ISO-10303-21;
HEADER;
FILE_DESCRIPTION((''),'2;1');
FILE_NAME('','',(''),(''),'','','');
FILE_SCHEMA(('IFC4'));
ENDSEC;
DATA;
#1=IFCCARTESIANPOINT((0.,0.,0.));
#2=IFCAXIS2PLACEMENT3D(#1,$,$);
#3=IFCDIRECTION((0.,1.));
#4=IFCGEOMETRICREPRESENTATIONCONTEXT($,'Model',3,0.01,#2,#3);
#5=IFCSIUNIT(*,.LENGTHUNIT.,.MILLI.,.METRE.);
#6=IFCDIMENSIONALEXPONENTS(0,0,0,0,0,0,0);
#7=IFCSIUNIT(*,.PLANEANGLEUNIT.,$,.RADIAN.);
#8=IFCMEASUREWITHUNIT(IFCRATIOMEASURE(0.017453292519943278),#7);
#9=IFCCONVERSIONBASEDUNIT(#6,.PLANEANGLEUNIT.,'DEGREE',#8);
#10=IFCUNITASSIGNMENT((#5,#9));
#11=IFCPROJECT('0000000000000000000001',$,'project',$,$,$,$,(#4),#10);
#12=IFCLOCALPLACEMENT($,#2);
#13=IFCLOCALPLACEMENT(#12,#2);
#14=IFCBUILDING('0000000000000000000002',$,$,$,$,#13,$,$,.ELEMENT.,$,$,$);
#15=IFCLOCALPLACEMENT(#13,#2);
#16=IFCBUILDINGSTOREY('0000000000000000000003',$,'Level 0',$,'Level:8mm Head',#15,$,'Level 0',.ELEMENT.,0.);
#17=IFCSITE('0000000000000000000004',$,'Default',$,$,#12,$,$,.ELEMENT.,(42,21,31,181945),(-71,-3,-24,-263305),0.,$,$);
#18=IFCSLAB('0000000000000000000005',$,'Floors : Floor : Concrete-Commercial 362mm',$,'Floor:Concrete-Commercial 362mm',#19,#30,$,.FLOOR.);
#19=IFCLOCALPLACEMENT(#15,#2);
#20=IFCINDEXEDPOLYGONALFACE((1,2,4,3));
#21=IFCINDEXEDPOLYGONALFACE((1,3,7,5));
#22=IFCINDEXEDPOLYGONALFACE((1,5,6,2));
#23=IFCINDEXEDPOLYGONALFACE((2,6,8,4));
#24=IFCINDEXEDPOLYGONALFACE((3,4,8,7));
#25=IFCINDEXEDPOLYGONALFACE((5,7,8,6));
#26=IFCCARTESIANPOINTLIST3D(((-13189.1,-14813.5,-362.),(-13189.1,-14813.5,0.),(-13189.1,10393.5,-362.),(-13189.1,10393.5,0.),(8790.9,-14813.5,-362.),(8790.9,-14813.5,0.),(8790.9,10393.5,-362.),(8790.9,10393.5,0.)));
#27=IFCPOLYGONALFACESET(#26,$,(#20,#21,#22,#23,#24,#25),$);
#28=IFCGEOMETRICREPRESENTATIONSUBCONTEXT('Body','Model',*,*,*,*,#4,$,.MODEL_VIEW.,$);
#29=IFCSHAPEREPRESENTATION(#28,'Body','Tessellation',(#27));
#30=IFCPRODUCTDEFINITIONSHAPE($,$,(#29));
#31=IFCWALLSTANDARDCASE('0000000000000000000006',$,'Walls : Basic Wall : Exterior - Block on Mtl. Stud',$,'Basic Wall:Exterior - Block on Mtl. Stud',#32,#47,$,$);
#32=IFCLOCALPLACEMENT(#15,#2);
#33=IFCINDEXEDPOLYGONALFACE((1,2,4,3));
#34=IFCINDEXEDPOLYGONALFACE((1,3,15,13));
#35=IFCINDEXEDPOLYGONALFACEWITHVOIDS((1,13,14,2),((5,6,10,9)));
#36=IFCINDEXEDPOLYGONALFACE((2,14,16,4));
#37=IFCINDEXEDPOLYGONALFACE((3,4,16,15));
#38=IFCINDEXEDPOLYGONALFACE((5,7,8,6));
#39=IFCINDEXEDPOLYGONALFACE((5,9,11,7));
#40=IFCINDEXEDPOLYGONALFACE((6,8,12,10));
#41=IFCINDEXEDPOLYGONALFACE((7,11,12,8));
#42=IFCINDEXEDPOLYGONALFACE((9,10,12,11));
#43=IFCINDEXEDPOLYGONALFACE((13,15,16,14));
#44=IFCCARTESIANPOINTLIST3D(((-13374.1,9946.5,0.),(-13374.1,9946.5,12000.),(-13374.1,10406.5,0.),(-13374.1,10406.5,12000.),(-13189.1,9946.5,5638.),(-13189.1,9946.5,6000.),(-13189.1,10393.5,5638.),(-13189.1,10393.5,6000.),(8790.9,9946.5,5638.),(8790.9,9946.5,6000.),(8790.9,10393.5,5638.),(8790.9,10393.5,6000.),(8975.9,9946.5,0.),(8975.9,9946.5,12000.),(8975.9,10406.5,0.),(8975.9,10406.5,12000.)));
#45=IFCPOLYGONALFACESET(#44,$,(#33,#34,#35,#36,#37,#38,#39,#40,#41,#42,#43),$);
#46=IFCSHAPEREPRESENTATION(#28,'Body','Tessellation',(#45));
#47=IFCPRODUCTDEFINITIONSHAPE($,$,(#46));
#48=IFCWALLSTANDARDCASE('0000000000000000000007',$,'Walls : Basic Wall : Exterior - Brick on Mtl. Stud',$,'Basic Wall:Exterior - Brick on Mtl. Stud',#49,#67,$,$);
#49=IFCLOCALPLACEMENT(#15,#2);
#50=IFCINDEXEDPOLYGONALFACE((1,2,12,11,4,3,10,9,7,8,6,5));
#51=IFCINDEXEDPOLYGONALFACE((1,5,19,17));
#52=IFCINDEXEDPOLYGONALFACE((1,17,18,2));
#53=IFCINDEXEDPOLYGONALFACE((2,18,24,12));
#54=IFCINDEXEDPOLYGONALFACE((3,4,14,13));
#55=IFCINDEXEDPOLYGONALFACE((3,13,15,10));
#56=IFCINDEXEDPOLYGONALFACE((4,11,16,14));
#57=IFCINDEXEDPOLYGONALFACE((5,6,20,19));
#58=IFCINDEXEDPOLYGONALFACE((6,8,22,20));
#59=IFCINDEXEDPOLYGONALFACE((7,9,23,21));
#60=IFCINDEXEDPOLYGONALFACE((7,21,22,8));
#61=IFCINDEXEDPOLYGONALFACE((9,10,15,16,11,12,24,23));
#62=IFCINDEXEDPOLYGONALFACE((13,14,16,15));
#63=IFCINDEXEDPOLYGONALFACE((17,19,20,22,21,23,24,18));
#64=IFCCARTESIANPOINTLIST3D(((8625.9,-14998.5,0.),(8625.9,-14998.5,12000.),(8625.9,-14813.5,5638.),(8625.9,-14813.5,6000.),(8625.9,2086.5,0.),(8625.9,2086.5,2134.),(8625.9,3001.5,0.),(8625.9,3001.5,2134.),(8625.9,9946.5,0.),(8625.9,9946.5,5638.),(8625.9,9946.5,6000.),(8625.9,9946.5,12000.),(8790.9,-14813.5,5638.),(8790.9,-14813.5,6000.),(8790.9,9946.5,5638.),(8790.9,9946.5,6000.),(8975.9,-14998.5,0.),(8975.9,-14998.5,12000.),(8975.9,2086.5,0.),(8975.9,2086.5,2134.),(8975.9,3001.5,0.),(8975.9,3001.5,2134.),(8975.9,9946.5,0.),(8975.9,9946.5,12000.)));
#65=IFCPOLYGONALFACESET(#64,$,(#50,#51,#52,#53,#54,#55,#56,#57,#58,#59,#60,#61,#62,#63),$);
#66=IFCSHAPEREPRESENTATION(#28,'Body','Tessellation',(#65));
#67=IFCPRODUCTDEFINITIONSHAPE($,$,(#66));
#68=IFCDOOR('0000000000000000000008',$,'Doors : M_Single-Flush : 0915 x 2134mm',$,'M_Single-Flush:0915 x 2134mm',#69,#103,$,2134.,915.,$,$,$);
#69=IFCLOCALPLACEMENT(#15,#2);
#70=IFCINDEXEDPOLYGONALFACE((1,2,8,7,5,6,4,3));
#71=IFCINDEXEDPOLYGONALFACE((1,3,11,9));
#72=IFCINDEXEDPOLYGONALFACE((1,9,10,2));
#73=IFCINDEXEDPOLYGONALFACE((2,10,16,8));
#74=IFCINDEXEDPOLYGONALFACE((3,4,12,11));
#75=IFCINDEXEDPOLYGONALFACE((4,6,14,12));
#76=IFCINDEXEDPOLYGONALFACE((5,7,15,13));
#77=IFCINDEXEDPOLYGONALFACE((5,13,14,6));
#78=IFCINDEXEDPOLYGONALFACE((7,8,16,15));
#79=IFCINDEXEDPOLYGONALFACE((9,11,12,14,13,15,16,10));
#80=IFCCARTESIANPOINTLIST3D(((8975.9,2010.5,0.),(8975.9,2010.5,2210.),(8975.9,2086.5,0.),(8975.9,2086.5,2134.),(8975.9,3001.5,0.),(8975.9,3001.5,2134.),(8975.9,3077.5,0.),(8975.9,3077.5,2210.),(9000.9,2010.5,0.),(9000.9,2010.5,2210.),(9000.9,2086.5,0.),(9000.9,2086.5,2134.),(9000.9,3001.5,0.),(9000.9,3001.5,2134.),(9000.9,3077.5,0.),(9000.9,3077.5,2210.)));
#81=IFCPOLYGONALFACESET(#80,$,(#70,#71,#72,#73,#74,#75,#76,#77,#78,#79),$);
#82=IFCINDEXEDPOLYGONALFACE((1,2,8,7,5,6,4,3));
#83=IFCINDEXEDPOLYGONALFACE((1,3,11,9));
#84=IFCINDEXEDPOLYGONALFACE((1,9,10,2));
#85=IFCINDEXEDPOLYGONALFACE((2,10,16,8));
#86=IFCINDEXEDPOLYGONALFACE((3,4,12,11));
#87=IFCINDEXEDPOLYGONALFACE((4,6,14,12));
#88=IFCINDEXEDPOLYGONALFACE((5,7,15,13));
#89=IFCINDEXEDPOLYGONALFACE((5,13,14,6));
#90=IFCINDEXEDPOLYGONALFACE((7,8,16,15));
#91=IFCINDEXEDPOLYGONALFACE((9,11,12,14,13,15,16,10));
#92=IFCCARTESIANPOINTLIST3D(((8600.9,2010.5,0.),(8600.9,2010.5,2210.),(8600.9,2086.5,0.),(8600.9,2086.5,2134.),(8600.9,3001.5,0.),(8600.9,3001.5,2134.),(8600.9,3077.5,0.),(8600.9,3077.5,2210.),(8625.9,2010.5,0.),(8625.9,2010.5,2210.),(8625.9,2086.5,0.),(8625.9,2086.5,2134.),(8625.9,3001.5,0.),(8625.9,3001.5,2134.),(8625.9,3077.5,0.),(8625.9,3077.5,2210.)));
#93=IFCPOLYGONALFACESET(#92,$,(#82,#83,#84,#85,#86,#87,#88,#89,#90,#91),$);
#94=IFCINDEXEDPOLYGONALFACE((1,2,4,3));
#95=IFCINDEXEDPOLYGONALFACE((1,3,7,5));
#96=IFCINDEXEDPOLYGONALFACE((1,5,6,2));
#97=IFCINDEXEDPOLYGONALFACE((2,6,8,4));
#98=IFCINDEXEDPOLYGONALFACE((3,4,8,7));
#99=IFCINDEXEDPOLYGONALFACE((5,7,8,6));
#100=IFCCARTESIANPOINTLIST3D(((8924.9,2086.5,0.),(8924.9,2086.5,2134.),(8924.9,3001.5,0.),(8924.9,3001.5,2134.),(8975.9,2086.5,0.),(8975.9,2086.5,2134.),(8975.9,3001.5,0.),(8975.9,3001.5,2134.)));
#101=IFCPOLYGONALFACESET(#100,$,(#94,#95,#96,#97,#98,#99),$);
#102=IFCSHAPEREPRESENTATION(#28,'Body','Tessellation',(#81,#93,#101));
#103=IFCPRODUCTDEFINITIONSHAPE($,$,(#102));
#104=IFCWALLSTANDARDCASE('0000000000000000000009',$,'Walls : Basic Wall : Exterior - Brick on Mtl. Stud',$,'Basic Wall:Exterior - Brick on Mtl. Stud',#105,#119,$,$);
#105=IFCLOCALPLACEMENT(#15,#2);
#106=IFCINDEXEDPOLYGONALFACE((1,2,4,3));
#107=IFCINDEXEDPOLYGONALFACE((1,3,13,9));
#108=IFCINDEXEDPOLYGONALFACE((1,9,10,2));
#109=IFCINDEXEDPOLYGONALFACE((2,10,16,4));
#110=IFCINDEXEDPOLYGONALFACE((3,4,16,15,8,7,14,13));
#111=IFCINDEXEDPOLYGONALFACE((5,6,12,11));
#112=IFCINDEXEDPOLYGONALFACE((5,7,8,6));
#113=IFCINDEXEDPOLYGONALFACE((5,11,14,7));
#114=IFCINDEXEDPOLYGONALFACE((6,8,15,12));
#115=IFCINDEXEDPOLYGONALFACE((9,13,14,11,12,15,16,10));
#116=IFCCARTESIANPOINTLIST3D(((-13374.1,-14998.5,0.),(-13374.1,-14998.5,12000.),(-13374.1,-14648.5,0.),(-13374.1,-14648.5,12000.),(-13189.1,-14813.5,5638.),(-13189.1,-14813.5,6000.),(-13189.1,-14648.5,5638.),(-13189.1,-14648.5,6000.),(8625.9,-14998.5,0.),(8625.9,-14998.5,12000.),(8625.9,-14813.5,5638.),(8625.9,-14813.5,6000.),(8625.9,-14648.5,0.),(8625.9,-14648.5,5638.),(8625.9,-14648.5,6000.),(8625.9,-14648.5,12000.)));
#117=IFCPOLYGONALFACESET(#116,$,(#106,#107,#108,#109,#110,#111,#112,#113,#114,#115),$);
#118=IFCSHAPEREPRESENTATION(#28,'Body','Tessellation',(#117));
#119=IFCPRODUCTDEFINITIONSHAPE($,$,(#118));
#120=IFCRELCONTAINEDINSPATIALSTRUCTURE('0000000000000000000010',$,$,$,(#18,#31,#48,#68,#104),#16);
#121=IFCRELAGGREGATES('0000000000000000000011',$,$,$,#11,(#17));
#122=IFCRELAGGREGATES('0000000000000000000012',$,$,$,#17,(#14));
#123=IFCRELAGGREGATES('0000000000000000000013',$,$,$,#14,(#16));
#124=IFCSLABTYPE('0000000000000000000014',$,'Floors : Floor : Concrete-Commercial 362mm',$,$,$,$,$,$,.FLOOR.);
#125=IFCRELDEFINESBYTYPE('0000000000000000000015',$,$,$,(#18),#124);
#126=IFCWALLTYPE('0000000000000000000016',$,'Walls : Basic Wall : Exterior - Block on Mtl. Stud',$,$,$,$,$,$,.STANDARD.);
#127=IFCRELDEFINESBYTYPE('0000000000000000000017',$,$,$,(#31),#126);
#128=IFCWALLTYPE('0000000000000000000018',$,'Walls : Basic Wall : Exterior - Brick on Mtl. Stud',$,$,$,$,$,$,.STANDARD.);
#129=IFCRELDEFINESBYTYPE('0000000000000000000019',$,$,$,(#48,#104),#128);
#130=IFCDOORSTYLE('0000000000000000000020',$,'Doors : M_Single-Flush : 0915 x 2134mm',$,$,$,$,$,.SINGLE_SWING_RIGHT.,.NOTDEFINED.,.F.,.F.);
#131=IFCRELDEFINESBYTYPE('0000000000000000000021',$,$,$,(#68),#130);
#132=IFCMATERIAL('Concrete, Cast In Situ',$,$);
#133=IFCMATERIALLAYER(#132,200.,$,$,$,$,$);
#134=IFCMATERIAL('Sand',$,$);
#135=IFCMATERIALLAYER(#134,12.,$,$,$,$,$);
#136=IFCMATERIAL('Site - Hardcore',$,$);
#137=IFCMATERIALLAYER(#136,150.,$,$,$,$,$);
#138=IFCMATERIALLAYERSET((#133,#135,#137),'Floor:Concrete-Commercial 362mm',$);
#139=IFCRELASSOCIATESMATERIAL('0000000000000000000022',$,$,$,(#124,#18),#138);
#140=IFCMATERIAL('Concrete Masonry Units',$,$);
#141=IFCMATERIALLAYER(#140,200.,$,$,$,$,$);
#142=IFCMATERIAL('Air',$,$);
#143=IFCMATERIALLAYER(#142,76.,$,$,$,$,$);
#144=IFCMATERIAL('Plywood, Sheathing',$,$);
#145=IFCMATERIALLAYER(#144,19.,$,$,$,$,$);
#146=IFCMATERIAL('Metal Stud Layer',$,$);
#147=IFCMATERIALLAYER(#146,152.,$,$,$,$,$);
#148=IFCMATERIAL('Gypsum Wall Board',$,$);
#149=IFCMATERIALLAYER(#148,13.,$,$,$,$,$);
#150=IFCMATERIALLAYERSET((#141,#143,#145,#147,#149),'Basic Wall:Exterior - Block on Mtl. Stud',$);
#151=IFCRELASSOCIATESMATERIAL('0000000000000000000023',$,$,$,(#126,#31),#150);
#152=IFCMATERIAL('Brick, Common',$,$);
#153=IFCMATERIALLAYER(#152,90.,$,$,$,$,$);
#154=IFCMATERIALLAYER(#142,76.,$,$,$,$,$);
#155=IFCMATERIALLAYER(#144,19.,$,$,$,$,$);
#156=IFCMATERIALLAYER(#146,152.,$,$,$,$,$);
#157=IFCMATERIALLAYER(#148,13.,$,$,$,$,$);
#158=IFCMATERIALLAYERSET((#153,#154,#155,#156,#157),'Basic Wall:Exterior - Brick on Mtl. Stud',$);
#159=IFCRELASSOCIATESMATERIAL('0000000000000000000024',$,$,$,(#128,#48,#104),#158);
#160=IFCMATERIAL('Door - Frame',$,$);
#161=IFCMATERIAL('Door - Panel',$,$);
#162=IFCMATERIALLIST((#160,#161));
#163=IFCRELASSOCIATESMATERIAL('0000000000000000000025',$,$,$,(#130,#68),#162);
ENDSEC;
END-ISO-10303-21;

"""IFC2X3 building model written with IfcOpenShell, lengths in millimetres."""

from ifc_helpers import new_model, entity, si_unit, converted_unit, direction, frame, frame_2d, origin, place, context, subcontext, project, spatial, polyline, rectangle, outline, extrude, source, transform, mapped, material, material_list, layer, layer_set, layer_usage, type_object, type_shapes, element, fill, save


model = new_model("IFC2X3")

# Units and contexts
model_context = context("Model", 3, precision=0.01, world=origin(), true_north=direction((0.0, 1.0)))
body_context = subcontext(model_context, "Body", "Model", "MODEL_VIEW")
ifc_project = project(units=[si_unit("LENGTHUNIT", "METRE", prefix="MILLI"), converted_unit("PLANEANGLEUNIT", "DEGREE", entity("IfcRatioMeasure", 0.017453292519943278), si_unit("PLANEANGLEUNIT", "RADIAN"), dimensions=[0, 0, 0, 0, 0, 0, 0])], contexts=[model_context])

# Site, building, storey
site_placement = place(None, origin())
site = spatial("IfcSite", under=ifc_project, at=site_placement, Name="Default", CompositionType="ELEMENT", RefLatitude=(42, 21, 31, 181945), RefLongitude=(-71, -3, -24, -263305), RefElevation=0.0)
building_placement = place(site_placement, origin())
building = spatial("IfcBuilding", under=site, at=building_placement, CompositionType="ELEMENT")
storey_placement = place(building_placement, origin())
storey = spatial("IfcBuildingStorey", under=building, at=storey_placement, Name="Level 0", ObjectType="Level:8mm Head", LongName="Level 0", CompositionType="ELEMENT", Elevation=0.0)

# Slab
ifc_material_1 = material(Name="Concrete, Cast In Situ")
ifc_layer_1 = layer(ifc_material_1, 200.0)
ifc_material_2 = material(Name="Sand")
ifc_layer_2 = layer(ifc_material_2, 12.0)
ifc_material_3 = material(Name="Site - Hardcore")
ifc_layer_3 = layer(ifc_material_3, 150.0)
ifc_layer_set_1 = layer_set([ifc_layer_1, ifc_layer_2, ifc_layer_3], Name="Floor:Concrete-Commercial 362mm")
ifc_layer_usage_1 = layer_usage(ifc_layer_set_1, "AXIS3", "POSITIVE", 0.0)
slab_type = type_object("IfcSlabType", Name="Floors : Floor : Concrete-Commercial 362mm", PredefinedType="FLOOR", material=ifc_layer_set_1)
slab_placement = place(storey_placement, origin())
element("IfcSlab", 1, at=slab_placement, inside=storey, type_object=slab_type, material=ifc_layer_usage_1, Name="Floors : Floor : Concrete-Commercial 362mm", ObjectType="Floor:Concrete-Commercial 362mm", PredefinedType="FLOOR", context=body_context, shape_type="SweptSolid", body=[
    extrude(rectangle(XDim=25207.0, YDim=21980.0, at=frame_2d((0.0, 0.0), x_axis=(1.0, 0.0))), frame((-2199.1, -2210.0, 0.0), z_axis=(0.0, 0.0, -1.0), x_axis=(0.0, 1.0, 0.0)), (0.0, 0.0, 1.0), 362.0),
])

# Wall, opening
ifc_material_4 = material(Name="Concrete Masonry Units")
ifc_layer_4 = layer(ifc_material_4, 200.0)
ifc_material_5 = material(Name="Air")
ifc_layer_5 = layer(ifc_material_5, 76.0)
ifc_material_6 = material(Name="Plywood, Sheathing")
ifc_layer_6 = layer(ifc_material_6, 19.0)
ifc_material_7 = material(Name="Metal Stud Layer")
ifc_layer_7 = layer(ifc_material_7, 152.0)
ifc_material_8 = material(Name="Gypsum Wall Board")
ifc_layer_8 = layer(ifc_material_8, 13.0)
ifc_layer_set_2 = layer_set([ifc_layer_4, ifc_layer_5, ifc_layer_6, ifc_layer_7, ifc_layer_8], Name="Basic Wall:Exterior - Block on Mtl. Stud")
ifc_layer_usage_2 = layer_usage(ifc_layer_set_2, "AXIS2", "POSITIVE", -230.0)
wall_type_1 = type_object("IfcWallType", Name="Walls : Basic Wall : Exterior - Block on Mtl. Stud", PredefinedType="STANDARD", material=ifc_layer_set_2)
wall_1_placement = place(storey_placement, frame((-13374.1, 10176.5, 0.0)))
wall_1 = element("IfcWallStandardCase", 2, at=wall_1_placement, inside=storey, type_object=wall_type_1, material=ifc_layer_usage_2, Name="Walls : Basic Wall : Exterior - Block on Mtl. Stud", ObjectType="Basic Wall:Exterior - Block on Mtl. Stud", context=body_context, shape_type="SweptSolid", body=[
    extrude(rectangle(XDim=22350.0, YDim=460.0, at=frame_2d((11175.0, 0.0), x_axis=(-1.0, 0.0))), origin(), (0.0, 0.0, 1.0), 12000.0),
])
opening_1_placement = place(storey_placement, frame((-13374.1, 10176.5, 0.0)))
element("IfcOpeningElement", 3, at=opening_1_placement, cuts=wall_1, ObjectType="Opening", context=body_context, shape_type="SweptSolid", body=[
    extrude(rectangle(XDim=21980.0, YDim=447.0, at=frame_2d((0.0, -74.5), x_axis=(1.0, 0.0))), frame((11175.0, -81.0, 5638.0), z_axis=(0.0, 0.0, 1.0), x_axis=(-1.0, 0.0, 0.0)), (0.0, 0.0, 1.0), 362.0),
])

# Wall, openings, door
ifc_material_9 = material(Name="Brick, Common")
ifc_layer_9 = layer(ifc_material_9, 90.0)
ifc_layer_10 = layer(ifc_material_5, 76.0)
ifc_layer_11 = layer(ifc_material_6, 19.0)
ifc_layer_12 = layer(ifc_material_7, 152.0)
ifc_layer_13 = layer(ifc_material_8, 13.0)
ifc_layer_set_3 = layer_set([ifc_layer_9, ifc_layer_10, ifc_layer_11, ifc_layer_12, ifc_layer_13], Name="Basic Wall:Exterior - Brick on Mtl. Stud")
ifc_layer_usage_3 = layer_usage(ifc_layer_set_3, "AXIS2", "NEGATIVE", 175.0)
wall_type_2 = type_object("IfcWallType", Name="Walls : Basic Wall : Exterior - Brick on Mtl. Stud", PredefinedType="STANDARD", material=ifc_layer_set_3)
wall_2_placement = place(storey_placement, frame((8800.9, 9946.5, 0.0), z_axis=(0.0, 0.0, 1.0), x_axis=(0.0, -1.0, 0.0)))
wall_2 = element("IfcWallStandardCase", 4, at=wall_2_placement, inside=storey, type_object=wall_type_2, material=ifc_layer_usage_3, Name="Walls : Basic Wall : Exterior - Brick on Mtl. Stud", ObjectType="Basic Wall:Exterior - Brick on Mtl. Stud", context=body_context, shape_type="SweptSolid", body=[
    extrude(rectangle(XDim=24945.0, YDim=350.0, at=frame_2d((12472.5, 0.0), x_axis=(-1.0, 0.0))), origin(), (0.0, 0.0, 1.0), 12000.0),
])
opening_2_placement = place(storey_placement, frame((8800.9, 9946.5, 0.0), z_axis=(0.0, 0.0, 1.0), x_axis=(0.0, -1.0, 0.0)))
element("IfcOpeningElement", 5, at=opening_2_placement, cuts=wall_2, ObjectType="Opening", context=body_context, shape_type="SweptSolid", body=[
    extrude(rectangle(XDim=165.0, YDim=24760.0, at=frame_2d((16.5, 2443.0), x_axis=(1.0, 0.0))), frame((14823.0, -109.0, 5638.0), z_axis=(0.0, 0.0, 1.0), x_axis=(0.0, 1.0, 0.0)), (0.0, 0.0, 1.0), 362.0),
])
opening_3_placement = place(wall_2_placement, frame((6945.0, -175.0, 0.0)))
opening_3 = element("IfcOpeningElement", 6, at=opening_3_placement, cuts=wall_2, ObjectType="Opening", context=body_context, shape_type="SweptSolid", body=[
    extrude(rectangle(XDim=915.0, YDim=2134.0, at=frame_2d((1067.0, 457.5), x_axis=(0.0, 1.0))), frame((0.0, 0.0, 0.0), z_axis=(0.0, 1.0, 0.0), x_axis=(0.0, 0.0, 1.0)), (0.0, 0.0, 1.0), 350.0),
])
ifc_material_10 = material(Name="Door - Frame")
ifc_material_11 = material(Name="Door - Panel")
ifc_material_list = material_list([ifc_material_10, ifc_material_11])
door_style_1 = type_object("IfcDoorStyle", Name="Doors : M_Single-Flush : 0915 x 2134mm", ConstructionType="NOTDEFINED", OperationType="SINGLE_SWING_RIGHT", ParameterTakesPrecedence=False, Sizeable=False, material=ifc_material_list)
shared_shape_1 = source(origin(), body_context, "Body", "SweptSolid", [
    extrude(outline(polyline([(-533.5, -1124.0), (533.5, -1124.0), (533.5, 1086.0), (457.5, 1086.0), (457.5, -1048.0), (-457.5, -1048.0), (-457.5, 1086.0), (-533.5, 1086.0), (-533.5, -1124.0)])), frame((457.5, 350.0, 1086.0), z_axis=(0.0, 1.0, 0.0), x_axis=(1.0, 0.0, 0.0)), (0.0, 0.0, 1.0), 25.0),
    extrude(outline(polyline([(-1124.0, -533.5), (1086.0, -533.5), (1086.0, -457.5), (-1048.0, -457.5), (-1048.0, 457.5), (1086.0, 457.5), (1086.0, 533.5), (-1124.0, 533.5), (-1124.0, -533.5)])), frame((457.5, -25.0, 1086.0), z_axis=(0.0, 1.0, 0.0), x_axis=(0.0, 0.0, -1.0)), (0.0, 0.0, 1.0), 25.0),
    extrude(rectangle(XDim=51.0, YDim=915.0, at=frame_2d((0.0, 0.0), x_axis=(1.0, 0.0))), frame((457.5, 324.5, 0.0), z_axis=(0.0, 0.0, 1.0), x_axis=(0.0, 1.0, 0.0)), (0.0, 0.0, 1.0), 2134.0),
])
type_shapes(door_style_1, [shared_shape_1])
door_1_placement = place(opening_3_placement, origin())
door_1 = element("IfcDoor", 7, at=door_1_placement, inside=storey, type_object=door_style_1, material=ifc_material_list, Name="Doors : M_Single-Flush : 0915 x 2134mm", ObjectType="M_Single-Flush:0915 x 2134mm", OverallHeight=2134.0, OverallWidth=915.0, context=body_context, shape_type="MappedRepresentation", body=[
    mapped(shared_shape_1, transform((0.0, 0.0, 0.0), scale=1.0)),
])
fill(opening_3, door_1)

# Wall, opening
wall_3_placement = place(storey_placement, frame((8625.9, -14823.5, 0.0), z_axis=(0.0, 0.0, 1.0), x_axis=(-1.0, 0.0, 0.0)))
wall_3 = element("IfcWallStandardCase", 8, at=wall_3_placement, inside=storey, type_object=wall_type_2, material=ifc_layer_usage_3, Name="Walls : Basic Wall : Exterior - Brick on Mtl. Stud", ObjectType="Basic Wall:Exterior - Brick on Mtl. Stud", context=body_context, shape_type="SweptSolid", body=[
    extrude(rectangle(XDim=22000.0, YDim=350.0, at=frame_2d((11000.0, 0.0), x_axis=(-1.0, 0.0))), origin(), (0.0, 0.0, 1.0), 12000.0),
])
opening_4_placement = place(storey_placement, frame((8625.9, -14823.5, 0.0), z_axis=(0.0, 0.0, 1.0), x_axis=(-1.0, 0.0, 0.0)))
element("IfcOpeningElement", 9, at=opening_4_placement, cuts=wall_3, ObjectType="Opening", context=body_context, shape_type="SweptSolid", body=[
    extrude(rectangle(XDim=165.0, YDim=21815.0, at=frame_2d((35.4, 82.5), x_axis=(1.0, 0.0))), frame((10990.0, -127.9, 5638.0), z_axis=(0.0, 0.0, 1.0), x_axis=(0.0, 1.0, 0.0)), (0.0, 0.0, 1.0), 362.0),
])

save(model, "model.ifc")
